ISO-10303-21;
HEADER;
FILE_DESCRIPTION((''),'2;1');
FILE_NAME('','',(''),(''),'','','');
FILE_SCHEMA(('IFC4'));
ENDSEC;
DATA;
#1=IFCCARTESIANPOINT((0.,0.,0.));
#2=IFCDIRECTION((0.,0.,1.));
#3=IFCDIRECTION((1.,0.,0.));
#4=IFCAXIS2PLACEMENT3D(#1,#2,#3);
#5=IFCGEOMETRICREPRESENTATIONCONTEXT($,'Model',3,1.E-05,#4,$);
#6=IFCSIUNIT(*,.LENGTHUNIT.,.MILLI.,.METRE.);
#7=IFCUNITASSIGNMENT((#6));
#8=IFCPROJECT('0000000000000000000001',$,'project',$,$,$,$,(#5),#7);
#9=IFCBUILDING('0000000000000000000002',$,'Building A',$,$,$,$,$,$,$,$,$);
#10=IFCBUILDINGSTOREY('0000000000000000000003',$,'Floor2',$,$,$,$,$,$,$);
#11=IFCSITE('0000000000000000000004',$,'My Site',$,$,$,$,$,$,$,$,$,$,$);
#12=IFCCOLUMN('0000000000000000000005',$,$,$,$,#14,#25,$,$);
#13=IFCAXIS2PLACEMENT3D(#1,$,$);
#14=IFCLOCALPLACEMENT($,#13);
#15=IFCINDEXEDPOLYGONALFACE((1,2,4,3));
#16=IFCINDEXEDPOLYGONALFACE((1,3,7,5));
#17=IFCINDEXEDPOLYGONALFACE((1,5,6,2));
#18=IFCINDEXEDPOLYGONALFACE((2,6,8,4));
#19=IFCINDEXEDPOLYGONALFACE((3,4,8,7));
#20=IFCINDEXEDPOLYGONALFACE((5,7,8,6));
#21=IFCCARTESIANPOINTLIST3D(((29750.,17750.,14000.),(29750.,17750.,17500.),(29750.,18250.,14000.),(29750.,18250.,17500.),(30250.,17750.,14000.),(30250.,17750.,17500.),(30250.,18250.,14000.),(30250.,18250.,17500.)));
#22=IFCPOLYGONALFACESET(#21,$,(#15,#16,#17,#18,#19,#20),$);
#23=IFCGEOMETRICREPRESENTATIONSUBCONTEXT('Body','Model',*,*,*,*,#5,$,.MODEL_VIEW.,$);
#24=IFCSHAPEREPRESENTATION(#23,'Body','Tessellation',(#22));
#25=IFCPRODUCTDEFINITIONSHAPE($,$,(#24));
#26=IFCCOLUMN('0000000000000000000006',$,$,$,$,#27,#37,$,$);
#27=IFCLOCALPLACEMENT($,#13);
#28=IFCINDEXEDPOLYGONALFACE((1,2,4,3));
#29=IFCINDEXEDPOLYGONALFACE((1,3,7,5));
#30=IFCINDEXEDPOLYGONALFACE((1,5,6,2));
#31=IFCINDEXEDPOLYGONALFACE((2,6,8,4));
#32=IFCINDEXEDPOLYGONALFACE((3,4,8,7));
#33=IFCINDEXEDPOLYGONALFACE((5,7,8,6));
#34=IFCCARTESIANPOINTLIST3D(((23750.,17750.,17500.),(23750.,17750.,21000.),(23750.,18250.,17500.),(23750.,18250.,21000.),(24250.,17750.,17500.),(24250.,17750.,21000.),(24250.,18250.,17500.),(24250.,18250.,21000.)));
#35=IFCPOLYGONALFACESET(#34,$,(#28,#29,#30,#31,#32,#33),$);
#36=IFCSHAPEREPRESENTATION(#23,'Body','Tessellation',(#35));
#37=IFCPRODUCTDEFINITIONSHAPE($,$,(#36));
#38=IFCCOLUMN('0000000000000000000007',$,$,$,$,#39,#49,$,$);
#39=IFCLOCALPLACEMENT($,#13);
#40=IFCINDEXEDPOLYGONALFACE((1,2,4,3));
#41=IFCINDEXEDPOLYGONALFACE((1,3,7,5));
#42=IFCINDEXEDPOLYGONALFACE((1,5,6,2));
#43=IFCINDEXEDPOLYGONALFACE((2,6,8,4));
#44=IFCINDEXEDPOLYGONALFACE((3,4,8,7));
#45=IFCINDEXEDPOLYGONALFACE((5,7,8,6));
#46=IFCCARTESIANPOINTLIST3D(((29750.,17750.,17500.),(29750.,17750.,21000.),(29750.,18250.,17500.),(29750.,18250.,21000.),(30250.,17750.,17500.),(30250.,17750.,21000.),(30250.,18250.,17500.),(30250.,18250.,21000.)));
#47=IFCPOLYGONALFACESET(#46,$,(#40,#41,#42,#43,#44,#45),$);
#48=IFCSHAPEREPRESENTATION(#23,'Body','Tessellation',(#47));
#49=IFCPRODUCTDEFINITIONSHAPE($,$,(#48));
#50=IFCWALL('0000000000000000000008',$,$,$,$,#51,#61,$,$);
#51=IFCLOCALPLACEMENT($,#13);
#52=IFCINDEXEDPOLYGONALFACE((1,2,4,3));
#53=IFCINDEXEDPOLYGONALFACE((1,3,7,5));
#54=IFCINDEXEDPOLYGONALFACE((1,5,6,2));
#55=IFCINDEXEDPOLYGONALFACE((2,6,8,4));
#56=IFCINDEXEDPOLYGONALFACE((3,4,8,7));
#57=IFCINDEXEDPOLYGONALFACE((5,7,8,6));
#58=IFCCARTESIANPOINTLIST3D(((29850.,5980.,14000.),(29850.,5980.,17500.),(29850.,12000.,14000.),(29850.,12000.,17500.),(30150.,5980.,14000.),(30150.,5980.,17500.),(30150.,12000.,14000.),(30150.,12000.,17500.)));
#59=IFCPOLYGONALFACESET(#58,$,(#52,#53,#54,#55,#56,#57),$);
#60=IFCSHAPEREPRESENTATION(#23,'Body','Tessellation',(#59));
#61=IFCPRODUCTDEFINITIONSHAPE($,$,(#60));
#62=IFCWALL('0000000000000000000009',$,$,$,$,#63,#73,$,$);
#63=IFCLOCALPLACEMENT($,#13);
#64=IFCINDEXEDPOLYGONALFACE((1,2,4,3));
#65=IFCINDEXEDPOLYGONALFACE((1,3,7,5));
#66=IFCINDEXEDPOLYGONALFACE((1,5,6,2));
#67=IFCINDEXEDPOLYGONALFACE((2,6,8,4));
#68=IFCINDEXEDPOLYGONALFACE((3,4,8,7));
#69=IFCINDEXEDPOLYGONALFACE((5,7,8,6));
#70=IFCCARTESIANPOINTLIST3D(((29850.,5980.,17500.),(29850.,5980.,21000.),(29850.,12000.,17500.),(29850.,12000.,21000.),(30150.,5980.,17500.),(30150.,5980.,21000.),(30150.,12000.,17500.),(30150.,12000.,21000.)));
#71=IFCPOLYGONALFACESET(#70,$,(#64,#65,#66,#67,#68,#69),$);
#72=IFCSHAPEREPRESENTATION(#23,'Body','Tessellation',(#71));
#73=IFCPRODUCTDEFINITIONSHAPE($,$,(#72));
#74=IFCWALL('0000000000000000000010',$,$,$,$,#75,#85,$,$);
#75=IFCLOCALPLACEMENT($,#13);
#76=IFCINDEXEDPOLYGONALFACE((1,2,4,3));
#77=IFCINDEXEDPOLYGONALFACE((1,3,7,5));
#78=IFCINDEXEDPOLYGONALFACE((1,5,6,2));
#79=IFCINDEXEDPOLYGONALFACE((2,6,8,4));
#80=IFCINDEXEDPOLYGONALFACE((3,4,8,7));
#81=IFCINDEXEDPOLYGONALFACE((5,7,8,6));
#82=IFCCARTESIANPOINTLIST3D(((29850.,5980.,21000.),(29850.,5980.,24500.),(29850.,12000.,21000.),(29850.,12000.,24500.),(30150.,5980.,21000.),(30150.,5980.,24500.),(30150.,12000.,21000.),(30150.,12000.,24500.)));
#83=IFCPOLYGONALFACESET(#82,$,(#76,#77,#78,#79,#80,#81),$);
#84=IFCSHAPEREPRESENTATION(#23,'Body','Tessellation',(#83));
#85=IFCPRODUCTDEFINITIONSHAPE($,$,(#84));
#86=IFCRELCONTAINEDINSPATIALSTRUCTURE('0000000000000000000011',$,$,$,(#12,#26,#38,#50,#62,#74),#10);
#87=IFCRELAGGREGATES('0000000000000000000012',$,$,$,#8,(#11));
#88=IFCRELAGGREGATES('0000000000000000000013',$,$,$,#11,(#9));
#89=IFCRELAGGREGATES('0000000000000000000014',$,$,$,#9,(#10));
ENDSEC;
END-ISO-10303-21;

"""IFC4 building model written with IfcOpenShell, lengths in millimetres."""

from ifc_helpers import new_model, si_unit, frame, origin_with_axes, place, context, subcontext, project, spatial, line, indexed_curve, outline, extrude, element, save


model = new_model("IFC4")

# Units and contexts
model_context = context("Model", 3, precision=1e-05, world=origin_with_axes())
body_context = subcontext(model_context, "Body", "Model", "MODEL_VIEW")
ifc_project = project(units=[si_unit("LENGTHUNIT", "METRE", prefix="MILLI")], contexts=[model_context])

# Site, building, storey
site = spatial("IfcSite", under=ifc_project, Name="My Site")
building = spatial("IfcBuilding", under=site, Name="Building A")
storey = spatial("IfcBuildingStorey", under=building, Name="Floor2")

# Columns
for number, where, z_axis, x_axis in (
    (1, (30000.0, 18000.0, 14000.0), (0.0, 0.0, 1.0), (1.0, 0.0, 0.0)),
    (2, (24000.0, 18000.0, 17500.0), (0.0, 0.0, 1.0), (1.0, 0.0, 0.0)),
    (3, (30000.0, 18000.0, 17500.0), (0.0, 0.0, 1.0), (1.0, 0.0, 0.0)),
):
    element("IfcColumn", number, at=place(None, frame(where, z_axis=z_axis, x_axis=x_axis)), inside=storey, context=body_context, shape_type="SweptSolid", body=[
        extrude(outline(indexed_curve([(-250.0, -250.0), (250.0, -250.0), (250.0, 250.0), (-250.0, 250.0)], segments=[line(1, 2, 3, 4, 1)])), origin_with_axes(), (0.0, 0.0, 1.0), 3500.0),
    ])

# Walls
for number, where, z_axis, x_axis in (
    (4, (29850.0, 12000.0, 14000.0), (0.0, 0.0, 1.0), (0.0, -1.0, 0.0)),
    (5, (29850.0, 12000.0, 17500.0), (0.0, 0.0, 1.0), (0.0, -1.0, 0.0)),
    (6, (29850.0, 12000.0, 21000.0), (0.0, 0.0, 1.0), (0.0, -1.0, 0.0)),
):
    element("IfcWall", number, at=place(None, frame(where, z_axis=z_axis, x_axis=x_axis)), inside=storey, context=body_context, shape_type="SweptSolid", body=[
        extrude(outline(indexed_curve([(0.0, 0.0), (0.0, 300.0), (6020.0, 300.0), (6020.0, 0.0), (0.0, 0.0)], self_intersect=False)), origin_with_axes(), (0.0, 0.0, 1.0), 3500.0),
    ])

save(model, "model.ifc")
